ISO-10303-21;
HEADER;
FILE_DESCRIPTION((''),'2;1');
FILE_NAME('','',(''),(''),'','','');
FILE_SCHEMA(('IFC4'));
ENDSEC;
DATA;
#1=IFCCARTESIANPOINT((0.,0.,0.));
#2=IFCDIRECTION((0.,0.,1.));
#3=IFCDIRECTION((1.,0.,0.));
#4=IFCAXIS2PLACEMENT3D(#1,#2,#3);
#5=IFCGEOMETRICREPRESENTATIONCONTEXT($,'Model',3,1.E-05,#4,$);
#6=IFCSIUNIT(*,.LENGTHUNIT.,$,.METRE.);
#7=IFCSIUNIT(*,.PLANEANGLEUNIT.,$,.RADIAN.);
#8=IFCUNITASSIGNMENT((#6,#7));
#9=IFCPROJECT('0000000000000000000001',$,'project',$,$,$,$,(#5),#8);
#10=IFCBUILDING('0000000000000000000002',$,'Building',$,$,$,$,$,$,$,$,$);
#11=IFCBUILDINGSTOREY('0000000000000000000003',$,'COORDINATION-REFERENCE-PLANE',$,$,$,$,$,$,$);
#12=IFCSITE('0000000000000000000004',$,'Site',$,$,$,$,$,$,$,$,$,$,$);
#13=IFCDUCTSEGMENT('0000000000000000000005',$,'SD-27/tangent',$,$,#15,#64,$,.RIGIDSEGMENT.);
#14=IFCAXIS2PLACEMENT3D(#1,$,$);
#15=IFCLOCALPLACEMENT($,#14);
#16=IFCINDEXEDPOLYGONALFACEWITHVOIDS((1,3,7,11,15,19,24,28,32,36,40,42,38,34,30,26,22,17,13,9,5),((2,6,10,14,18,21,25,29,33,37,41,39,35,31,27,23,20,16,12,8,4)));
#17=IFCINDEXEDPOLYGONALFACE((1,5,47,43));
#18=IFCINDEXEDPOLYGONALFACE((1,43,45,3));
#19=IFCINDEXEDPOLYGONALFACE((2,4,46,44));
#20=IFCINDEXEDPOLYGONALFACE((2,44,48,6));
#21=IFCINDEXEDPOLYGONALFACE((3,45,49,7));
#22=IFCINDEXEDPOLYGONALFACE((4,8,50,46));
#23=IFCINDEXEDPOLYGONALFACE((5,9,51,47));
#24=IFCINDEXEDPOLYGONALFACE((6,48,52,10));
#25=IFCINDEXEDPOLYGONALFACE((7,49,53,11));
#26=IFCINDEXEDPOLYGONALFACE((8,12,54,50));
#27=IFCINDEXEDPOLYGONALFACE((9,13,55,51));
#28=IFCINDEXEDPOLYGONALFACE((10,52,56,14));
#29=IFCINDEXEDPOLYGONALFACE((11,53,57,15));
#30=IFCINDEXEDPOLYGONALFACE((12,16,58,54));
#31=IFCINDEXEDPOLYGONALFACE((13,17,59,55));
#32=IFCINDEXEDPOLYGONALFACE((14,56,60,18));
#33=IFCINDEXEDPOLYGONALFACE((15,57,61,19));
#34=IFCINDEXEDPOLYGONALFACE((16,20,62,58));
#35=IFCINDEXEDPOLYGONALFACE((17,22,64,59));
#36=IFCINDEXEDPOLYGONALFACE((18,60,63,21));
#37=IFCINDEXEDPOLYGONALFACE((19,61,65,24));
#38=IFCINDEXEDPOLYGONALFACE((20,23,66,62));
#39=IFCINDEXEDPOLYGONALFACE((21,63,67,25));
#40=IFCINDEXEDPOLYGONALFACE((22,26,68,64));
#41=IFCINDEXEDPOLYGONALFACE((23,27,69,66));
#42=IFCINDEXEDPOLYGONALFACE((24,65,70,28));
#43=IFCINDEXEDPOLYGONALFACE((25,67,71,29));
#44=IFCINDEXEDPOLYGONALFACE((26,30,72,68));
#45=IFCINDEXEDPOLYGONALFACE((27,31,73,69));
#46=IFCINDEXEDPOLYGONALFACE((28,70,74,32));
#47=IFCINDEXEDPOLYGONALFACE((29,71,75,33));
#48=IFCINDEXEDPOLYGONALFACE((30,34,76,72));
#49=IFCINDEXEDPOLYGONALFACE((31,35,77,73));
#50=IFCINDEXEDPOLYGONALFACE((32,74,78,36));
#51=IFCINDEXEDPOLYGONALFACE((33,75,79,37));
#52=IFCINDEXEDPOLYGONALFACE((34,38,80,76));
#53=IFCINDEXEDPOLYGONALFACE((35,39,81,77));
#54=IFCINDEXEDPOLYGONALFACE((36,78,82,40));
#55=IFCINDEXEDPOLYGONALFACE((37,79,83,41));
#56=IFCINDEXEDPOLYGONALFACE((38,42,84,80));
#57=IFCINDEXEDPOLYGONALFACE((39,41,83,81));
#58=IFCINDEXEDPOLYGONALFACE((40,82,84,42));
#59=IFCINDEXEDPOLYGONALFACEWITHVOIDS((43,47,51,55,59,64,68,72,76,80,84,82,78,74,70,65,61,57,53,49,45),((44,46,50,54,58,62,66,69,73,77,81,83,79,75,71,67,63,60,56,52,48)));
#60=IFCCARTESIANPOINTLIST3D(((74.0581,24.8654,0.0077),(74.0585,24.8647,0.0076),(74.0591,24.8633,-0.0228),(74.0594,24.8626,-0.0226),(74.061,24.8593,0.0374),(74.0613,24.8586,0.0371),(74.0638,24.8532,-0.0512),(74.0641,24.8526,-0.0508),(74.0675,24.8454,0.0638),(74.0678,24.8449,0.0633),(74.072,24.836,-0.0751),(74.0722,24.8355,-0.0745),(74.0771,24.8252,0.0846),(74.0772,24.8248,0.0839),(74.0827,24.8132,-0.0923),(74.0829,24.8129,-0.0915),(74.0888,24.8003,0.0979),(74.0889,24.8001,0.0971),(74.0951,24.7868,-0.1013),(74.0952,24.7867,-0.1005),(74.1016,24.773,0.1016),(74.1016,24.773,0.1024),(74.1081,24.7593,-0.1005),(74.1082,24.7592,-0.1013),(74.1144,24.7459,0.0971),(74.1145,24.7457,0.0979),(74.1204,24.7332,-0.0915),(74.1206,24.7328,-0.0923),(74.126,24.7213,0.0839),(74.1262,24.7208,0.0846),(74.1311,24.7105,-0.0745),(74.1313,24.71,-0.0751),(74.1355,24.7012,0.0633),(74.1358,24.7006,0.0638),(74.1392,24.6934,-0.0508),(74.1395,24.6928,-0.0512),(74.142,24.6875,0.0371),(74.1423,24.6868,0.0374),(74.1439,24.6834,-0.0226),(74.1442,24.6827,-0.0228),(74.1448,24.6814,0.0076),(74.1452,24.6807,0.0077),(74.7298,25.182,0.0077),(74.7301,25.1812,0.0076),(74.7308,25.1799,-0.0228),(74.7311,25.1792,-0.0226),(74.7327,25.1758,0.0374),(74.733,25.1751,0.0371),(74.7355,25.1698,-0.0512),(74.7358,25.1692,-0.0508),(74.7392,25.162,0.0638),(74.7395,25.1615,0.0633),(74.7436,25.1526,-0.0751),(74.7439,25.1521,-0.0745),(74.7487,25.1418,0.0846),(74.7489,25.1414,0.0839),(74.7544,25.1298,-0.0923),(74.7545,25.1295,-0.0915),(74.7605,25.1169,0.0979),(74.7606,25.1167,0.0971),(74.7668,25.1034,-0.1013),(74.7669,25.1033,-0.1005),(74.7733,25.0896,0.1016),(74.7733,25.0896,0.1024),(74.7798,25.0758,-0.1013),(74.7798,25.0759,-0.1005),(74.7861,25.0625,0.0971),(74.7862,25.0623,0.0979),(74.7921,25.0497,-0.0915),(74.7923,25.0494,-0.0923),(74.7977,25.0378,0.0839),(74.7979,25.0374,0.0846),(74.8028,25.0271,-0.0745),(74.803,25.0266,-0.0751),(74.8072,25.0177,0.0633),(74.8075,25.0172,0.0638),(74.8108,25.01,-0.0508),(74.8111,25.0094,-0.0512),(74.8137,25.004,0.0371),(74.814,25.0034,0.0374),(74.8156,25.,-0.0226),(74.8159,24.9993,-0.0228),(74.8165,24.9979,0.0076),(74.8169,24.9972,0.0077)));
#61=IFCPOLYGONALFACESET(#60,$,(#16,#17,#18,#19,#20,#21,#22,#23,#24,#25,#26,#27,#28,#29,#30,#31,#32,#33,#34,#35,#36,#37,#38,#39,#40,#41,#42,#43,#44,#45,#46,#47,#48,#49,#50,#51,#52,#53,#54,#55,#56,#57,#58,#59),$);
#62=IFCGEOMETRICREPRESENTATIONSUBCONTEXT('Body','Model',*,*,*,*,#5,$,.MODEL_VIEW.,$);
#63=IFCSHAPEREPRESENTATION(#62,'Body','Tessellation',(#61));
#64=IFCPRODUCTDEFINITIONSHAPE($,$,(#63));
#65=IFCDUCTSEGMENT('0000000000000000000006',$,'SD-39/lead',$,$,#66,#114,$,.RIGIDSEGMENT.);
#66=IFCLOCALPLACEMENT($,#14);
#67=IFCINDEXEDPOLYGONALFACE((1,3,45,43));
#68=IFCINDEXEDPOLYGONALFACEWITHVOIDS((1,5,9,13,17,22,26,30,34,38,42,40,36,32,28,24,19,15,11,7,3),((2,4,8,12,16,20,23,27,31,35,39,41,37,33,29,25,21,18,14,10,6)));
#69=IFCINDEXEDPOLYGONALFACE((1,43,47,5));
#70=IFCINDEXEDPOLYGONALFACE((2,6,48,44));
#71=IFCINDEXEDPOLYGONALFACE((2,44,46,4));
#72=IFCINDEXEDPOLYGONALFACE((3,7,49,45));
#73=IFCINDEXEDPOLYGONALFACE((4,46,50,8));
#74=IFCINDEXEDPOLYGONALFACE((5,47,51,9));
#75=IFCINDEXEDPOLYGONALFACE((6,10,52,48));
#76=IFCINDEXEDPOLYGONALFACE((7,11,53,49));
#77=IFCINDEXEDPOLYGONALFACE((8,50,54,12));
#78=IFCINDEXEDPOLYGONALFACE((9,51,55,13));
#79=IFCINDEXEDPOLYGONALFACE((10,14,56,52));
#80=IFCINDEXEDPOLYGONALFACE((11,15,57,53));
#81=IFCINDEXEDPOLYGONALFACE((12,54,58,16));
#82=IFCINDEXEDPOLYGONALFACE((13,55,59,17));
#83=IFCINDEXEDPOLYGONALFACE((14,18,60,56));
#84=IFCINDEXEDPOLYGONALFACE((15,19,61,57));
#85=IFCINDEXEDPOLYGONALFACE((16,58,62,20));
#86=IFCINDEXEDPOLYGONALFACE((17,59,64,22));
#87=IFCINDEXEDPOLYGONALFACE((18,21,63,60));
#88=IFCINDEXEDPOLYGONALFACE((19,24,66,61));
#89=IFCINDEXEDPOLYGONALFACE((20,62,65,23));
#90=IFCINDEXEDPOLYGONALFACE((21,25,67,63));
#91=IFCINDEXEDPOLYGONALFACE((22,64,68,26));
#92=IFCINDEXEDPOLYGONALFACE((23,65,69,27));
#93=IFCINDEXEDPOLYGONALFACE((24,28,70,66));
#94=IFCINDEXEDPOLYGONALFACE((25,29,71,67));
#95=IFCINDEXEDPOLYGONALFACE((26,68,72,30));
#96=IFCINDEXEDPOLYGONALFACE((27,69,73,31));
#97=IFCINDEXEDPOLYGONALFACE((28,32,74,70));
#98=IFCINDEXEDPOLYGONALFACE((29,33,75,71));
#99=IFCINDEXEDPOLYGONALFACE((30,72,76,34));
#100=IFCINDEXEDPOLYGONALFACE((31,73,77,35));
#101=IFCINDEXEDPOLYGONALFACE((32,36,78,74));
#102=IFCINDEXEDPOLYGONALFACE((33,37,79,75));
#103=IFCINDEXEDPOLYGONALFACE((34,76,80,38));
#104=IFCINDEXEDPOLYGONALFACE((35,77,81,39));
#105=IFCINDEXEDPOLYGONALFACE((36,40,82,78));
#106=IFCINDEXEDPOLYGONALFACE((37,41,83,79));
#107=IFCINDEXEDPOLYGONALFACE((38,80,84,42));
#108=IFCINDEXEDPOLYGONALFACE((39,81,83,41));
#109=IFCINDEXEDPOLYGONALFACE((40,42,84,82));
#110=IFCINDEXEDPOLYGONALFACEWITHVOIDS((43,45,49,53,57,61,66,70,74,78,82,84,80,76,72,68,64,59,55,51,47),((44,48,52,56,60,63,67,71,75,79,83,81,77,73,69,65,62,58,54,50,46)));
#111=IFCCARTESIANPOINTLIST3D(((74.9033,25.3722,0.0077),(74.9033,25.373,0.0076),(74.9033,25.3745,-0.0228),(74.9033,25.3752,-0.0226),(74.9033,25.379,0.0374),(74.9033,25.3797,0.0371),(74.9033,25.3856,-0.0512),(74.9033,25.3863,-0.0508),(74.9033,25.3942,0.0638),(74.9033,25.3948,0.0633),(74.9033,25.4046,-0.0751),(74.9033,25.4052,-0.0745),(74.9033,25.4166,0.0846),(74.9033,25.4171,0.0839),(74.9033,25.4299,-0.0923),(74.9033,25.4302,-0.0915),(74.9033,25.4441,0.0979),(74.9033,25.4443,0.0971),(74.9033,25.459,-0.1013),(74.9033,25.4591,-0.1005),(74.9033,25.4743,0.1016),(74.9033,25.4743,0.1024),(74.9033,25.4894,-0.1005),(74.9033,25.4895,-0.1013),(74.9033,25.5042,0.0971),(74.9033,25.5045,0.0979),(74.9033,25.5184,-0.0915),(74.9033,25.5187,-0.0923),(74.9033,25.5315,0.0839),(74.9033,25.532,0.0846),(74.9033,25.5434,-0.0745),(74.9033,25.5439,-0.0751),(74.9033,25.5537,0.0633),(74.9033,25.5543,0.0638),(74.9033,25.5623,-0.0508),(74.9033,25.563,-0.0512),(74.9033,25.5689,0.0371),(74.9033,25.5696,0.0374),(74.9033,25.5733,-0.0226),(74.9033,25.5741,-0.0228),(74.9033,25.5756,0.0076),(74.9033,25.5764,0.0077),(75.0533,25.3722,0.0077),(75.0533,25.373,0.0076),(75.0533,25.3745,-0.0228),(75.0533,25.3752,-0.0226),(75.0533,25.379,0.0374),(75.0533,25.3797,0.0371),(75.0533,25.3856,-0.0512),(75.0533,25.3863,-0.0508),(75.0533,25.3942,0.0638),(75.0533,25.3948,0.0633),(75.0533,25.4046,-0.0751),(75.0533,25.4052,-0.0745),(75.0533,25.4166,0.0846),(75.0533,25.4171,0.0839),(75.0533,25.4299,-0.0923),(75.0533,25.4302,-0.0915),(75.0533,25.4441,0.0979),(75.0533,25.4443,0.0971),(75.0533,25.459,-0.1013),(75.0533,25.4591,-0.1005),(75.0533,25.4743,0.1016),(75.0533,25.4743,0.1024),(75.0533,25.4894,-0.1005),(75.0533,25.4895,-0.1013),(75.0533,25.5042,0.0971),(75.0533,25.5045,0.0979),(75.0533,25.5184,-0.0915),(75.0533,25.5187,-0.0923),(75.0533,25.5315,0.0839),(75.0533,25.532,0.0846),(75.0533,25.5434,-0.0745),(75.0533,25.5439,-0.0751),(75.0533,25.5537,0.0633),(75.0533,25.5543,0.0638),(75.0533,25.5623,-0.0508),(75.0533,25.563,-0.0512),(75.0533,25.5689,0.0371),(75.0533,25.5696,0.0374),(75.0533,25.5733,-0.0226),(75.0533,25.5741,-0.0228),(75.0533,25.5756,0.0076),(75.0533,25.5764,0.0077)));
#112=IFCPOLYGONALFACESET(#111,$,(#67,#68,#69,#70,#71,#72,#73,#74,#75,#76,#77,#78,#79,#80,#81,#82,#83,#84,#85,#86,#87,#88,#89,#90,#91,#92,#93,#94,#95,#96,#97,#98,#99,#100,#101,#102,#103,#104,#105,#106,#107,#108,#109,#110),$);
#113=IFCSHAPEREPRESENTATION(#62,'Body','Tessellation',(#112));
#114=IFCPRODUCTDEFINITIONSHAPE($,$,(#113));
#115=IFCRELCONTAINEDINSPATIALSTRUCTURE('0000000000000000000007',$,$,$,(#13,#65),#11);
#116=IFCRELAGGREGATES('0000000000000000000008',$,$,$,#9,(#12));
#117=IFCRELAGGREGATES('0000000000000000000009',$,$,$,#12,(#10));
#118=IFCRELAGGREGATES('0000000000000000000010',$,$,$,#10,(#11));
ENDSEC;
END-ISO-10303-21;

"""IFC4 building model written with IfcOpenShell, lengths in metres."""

from ifc_helpers import new_model, si_unit, frame, origin_with_axes, place, context, subcontext, project, spatial, hollow_circle, extrude, element, save


model = new_model("IFC4")

# Units and contexts
model_context = context("Model", 3, precision=1e-05, world=origin_with_axes())
body_context_1 = subcontext(model_context, "Body", "Model", "MODEL_VIEW")
ifc_project = project(units=[si_unit("LENGTHUNIT", "METRE"), si_unit("PLANEANGLEUNIT", "RADIAN")], contexts=[model_context])

# Site, building, storey
site = spatial("IfcSite", under=ifc_project, Name="Site")
building = spatial("IfcBuilding", under=site, Name="Building")
storey = spatial("IfcBuildingStorey", under=building, Name="COORDINATION-REFERENCE-PLANE")

# Duct segment
duct_segment_1_placement = place(None, frame((74.7733, 25.0896, 0.0), z_axis=(-0.904569, -0.426327, 0.0), x_axis=(0.0, 0.0, 1.0)))
element("IfcDuctSegment", 1, at=duct_segment_1_placement, inside=storey, Name="SD-27/tangent", PredefinedType="RIGIDSEGMENT", context=body_context_1, shape_type="SweptSolid", body=[
    extrude(hollow_circle(Radius=0.1024, WallThickness=0.0008), origin_with_axes(), (0.0, 0.0, 1.0), 0.7425),
])

# Duct segment
duct_segment_2_placement = place(None, frame((75.0533, 25.4743, 0.0), z_axis=(-1.0, 0.0, 0.0), x_axis=(0.0, 0.0, 1.0)))
element("IfcDuctSegment", 2, at=duct_segment_2_placement, inside=storey, Name="SD-39/lead", PredefinedType="RIGIDSEGMENT", context=body_context_1, shape_type="SweptSolid", body=[
    extrude(hollow_circle(Radius=0.1024, WallThickness=0.0008), origin_with_axes(), (0.0, 0.0, 1.0), 0.15),
])

save(model, "model.ifc")
